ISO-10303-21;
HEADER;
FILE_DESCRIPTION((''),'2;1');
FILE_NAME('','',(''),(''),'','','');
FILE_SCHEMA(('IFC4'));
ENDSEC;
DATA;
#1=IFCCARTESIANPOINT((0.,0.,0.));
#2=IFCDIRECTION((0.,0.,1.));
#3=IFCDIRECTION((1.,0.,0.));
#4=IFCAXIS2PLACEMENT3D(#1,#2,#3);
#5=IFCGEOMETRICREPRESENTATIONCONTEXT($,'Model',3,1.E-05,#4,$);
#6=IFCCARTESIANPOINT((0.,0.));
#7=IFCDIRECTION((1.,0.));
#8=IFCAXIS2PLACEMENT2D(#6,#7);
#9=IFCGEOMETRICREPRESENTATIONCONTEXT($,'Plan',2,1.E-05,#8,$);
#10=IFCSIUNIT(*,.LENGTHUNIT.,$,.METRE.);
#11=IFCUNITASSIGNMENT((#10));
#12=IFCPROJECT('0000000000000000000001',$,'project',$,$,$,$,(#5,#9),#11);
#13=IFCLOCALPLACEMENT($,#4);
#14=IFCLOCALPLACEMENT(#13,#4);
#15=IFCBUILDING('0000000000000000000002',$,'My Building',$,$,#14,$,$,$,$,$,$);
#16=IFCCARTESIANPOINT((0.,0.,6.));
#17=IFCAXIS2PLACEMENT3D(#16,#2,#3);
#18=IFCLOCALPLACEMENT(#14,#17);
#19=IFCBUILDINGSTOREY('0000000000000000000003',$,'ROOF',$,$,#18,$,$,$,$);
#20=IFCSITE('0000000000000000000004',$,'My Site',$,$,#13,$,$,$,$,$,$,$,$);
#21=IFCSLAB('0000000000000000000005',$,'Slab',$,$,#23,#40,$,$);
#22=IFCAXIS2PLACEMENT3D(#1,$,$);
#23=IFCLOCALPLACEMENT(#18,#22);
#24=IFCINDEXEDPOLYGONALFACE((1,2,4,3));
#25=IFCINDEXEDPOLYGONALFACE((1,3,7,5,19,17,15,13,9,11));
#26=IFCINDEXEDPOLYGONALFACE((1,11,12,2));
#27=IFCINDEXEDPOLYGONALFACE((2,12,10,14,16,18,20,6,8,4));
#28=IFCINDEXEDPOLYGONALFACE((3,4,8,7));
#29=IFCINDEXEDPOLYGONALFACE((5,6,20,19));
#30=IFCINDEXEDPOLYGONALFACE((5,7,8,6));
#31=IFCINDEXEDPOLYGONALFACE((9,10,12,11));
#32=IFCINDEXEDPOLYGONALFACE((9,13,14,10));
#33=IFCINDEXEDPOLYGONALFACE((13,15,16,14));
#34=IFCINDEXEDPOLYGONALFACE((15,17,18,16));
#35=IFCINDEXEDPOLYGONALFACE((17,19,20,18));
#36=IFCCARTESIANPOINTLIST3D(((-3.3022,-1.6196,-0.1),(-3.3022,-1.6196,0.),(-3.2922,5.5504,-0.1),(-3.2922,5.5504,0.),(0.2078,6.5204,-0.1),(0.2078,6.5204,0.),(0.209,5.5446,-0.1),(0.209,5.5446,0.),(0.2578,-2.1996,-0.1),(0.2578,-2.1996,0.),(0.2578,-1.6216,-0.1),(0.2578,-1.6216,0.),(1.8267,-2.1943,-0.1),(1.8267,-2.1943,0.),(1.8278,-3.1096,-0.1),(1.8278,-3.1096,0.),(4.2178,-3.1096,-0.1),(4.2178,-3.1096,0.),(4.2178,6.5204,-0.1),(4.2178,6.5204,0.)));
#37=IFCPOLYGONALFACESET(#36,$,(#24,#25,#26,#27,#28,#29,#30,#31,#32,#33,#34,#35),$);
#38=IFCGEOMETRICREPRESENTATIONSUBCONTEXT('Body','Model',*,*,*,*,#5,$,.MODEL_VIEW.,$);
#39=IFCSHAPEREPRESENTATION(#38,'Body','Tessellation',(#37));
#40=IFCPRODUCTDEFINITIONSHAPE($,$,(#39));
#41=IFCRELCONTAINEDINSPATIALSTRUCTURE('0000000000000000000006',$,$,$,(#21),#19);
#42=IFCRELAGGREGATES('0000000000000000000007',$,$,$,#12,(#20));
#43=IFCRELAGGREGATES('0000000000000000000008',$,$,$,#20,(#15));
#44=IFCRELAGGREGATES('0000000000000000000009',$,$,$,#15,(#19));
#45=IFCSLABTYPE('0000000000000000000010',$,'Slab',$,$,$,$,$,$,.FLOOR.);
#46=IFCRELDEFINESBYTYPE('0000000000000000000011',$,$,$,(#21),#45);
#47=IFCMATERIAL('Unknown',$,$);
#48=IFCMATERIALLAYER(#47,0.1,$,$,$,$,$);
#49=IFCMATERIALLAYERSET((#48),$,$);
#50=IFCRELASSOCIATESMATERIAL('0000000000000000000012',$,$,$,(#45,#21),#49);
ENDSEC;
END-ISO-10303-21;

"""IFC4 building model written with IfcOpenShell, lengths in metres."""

from ifc_helpers import new_model, si_unit, frame, origin_with_axes, origin_2d_with_axis, place, context, subcontext, project, spatial, indexed_curve, outline, extrude, material, layer, layer_set, layer_usage, type_object, element, save


model = new_model("IFC4")

# Units and contexts
model_context = context("Model", 3, precision=1e-05, world=origin_with_axes())
plan_context = context("Plan", 2, precision=1e-05, world=origin_2d_with_axis())
body_context = subcontext(model_context, "Body", "Model", "MODEL_VIEW")
ifc_project = project(units=[si_unit("LENGTHUNIT", "METRE")], contexts=[model_context, plan_context])

# Site, building, storey
site_placement = place(None, origin_with_axes())
site = spatial("IfcSite", under=ifc_project, at=site_placement, Name="My Site")
building_placement = place(site_placement, origin_with_axes())
building = spatial("IfcBuilding", under=site, at=building_placement, Name="My Building")
storey_placement = place(building_placement, frame((0.0, 0.0, 6.0), z_axis=(0.0, 0.0, 1.0), x_axis=(1.0, 0.0, 0.0)))
storey = spatial("IfcBuildingStorey", under=building, at=storey_placement, Name="ROOF")

# Slab
ifc_material = material(Name="Unknown")
ifc_layer = layer(ifc_material, 0.1)
ifc_layer_set = layer_set([ifc_layer])
ifc_layer_usage = layer_usage(ifc_layer_set, "AXIS3", "POSITIVE", -0.1)
slab_type = type_object("IfcSlabType", Name="Slab", PredefinedType="FLOOR", material=ifc_layer_set)
slab_placement = place(storey_placement, frame((-3.2922, 5.5504, 0.0), z_axis=(0.0, 0.0, 1.0), x_axis=(1.0, 0.0, 0.0)))
element("IfcSlab", 1, at=slab_placement, inside=storey, type_object=slab_type, material=ifc_layer_usage, Name="Slab", context=body_context, shape_type="SweptSolid", body=[
    extrude(outline(indexed_curve([(0.0, 0.0), (-0.01, -7.17), (3.55, -7.172), (3.55, -7.75), (5.1189, -7.7447), (5.12, -8.66), (7.51, -8.66), (7.51, 0.97), (3.5, 0.97), (3.5012, -0.0058), (0.0, 0.0)])), frame((0.0, 0.0, -0.1), z_axis=(0.0, 0.0, 1.0), x_axis=(1.0, 0.0, 0.0)), (0.0, 0.0, 1.0), 0.1),
])

save(model, "model.ifc")
